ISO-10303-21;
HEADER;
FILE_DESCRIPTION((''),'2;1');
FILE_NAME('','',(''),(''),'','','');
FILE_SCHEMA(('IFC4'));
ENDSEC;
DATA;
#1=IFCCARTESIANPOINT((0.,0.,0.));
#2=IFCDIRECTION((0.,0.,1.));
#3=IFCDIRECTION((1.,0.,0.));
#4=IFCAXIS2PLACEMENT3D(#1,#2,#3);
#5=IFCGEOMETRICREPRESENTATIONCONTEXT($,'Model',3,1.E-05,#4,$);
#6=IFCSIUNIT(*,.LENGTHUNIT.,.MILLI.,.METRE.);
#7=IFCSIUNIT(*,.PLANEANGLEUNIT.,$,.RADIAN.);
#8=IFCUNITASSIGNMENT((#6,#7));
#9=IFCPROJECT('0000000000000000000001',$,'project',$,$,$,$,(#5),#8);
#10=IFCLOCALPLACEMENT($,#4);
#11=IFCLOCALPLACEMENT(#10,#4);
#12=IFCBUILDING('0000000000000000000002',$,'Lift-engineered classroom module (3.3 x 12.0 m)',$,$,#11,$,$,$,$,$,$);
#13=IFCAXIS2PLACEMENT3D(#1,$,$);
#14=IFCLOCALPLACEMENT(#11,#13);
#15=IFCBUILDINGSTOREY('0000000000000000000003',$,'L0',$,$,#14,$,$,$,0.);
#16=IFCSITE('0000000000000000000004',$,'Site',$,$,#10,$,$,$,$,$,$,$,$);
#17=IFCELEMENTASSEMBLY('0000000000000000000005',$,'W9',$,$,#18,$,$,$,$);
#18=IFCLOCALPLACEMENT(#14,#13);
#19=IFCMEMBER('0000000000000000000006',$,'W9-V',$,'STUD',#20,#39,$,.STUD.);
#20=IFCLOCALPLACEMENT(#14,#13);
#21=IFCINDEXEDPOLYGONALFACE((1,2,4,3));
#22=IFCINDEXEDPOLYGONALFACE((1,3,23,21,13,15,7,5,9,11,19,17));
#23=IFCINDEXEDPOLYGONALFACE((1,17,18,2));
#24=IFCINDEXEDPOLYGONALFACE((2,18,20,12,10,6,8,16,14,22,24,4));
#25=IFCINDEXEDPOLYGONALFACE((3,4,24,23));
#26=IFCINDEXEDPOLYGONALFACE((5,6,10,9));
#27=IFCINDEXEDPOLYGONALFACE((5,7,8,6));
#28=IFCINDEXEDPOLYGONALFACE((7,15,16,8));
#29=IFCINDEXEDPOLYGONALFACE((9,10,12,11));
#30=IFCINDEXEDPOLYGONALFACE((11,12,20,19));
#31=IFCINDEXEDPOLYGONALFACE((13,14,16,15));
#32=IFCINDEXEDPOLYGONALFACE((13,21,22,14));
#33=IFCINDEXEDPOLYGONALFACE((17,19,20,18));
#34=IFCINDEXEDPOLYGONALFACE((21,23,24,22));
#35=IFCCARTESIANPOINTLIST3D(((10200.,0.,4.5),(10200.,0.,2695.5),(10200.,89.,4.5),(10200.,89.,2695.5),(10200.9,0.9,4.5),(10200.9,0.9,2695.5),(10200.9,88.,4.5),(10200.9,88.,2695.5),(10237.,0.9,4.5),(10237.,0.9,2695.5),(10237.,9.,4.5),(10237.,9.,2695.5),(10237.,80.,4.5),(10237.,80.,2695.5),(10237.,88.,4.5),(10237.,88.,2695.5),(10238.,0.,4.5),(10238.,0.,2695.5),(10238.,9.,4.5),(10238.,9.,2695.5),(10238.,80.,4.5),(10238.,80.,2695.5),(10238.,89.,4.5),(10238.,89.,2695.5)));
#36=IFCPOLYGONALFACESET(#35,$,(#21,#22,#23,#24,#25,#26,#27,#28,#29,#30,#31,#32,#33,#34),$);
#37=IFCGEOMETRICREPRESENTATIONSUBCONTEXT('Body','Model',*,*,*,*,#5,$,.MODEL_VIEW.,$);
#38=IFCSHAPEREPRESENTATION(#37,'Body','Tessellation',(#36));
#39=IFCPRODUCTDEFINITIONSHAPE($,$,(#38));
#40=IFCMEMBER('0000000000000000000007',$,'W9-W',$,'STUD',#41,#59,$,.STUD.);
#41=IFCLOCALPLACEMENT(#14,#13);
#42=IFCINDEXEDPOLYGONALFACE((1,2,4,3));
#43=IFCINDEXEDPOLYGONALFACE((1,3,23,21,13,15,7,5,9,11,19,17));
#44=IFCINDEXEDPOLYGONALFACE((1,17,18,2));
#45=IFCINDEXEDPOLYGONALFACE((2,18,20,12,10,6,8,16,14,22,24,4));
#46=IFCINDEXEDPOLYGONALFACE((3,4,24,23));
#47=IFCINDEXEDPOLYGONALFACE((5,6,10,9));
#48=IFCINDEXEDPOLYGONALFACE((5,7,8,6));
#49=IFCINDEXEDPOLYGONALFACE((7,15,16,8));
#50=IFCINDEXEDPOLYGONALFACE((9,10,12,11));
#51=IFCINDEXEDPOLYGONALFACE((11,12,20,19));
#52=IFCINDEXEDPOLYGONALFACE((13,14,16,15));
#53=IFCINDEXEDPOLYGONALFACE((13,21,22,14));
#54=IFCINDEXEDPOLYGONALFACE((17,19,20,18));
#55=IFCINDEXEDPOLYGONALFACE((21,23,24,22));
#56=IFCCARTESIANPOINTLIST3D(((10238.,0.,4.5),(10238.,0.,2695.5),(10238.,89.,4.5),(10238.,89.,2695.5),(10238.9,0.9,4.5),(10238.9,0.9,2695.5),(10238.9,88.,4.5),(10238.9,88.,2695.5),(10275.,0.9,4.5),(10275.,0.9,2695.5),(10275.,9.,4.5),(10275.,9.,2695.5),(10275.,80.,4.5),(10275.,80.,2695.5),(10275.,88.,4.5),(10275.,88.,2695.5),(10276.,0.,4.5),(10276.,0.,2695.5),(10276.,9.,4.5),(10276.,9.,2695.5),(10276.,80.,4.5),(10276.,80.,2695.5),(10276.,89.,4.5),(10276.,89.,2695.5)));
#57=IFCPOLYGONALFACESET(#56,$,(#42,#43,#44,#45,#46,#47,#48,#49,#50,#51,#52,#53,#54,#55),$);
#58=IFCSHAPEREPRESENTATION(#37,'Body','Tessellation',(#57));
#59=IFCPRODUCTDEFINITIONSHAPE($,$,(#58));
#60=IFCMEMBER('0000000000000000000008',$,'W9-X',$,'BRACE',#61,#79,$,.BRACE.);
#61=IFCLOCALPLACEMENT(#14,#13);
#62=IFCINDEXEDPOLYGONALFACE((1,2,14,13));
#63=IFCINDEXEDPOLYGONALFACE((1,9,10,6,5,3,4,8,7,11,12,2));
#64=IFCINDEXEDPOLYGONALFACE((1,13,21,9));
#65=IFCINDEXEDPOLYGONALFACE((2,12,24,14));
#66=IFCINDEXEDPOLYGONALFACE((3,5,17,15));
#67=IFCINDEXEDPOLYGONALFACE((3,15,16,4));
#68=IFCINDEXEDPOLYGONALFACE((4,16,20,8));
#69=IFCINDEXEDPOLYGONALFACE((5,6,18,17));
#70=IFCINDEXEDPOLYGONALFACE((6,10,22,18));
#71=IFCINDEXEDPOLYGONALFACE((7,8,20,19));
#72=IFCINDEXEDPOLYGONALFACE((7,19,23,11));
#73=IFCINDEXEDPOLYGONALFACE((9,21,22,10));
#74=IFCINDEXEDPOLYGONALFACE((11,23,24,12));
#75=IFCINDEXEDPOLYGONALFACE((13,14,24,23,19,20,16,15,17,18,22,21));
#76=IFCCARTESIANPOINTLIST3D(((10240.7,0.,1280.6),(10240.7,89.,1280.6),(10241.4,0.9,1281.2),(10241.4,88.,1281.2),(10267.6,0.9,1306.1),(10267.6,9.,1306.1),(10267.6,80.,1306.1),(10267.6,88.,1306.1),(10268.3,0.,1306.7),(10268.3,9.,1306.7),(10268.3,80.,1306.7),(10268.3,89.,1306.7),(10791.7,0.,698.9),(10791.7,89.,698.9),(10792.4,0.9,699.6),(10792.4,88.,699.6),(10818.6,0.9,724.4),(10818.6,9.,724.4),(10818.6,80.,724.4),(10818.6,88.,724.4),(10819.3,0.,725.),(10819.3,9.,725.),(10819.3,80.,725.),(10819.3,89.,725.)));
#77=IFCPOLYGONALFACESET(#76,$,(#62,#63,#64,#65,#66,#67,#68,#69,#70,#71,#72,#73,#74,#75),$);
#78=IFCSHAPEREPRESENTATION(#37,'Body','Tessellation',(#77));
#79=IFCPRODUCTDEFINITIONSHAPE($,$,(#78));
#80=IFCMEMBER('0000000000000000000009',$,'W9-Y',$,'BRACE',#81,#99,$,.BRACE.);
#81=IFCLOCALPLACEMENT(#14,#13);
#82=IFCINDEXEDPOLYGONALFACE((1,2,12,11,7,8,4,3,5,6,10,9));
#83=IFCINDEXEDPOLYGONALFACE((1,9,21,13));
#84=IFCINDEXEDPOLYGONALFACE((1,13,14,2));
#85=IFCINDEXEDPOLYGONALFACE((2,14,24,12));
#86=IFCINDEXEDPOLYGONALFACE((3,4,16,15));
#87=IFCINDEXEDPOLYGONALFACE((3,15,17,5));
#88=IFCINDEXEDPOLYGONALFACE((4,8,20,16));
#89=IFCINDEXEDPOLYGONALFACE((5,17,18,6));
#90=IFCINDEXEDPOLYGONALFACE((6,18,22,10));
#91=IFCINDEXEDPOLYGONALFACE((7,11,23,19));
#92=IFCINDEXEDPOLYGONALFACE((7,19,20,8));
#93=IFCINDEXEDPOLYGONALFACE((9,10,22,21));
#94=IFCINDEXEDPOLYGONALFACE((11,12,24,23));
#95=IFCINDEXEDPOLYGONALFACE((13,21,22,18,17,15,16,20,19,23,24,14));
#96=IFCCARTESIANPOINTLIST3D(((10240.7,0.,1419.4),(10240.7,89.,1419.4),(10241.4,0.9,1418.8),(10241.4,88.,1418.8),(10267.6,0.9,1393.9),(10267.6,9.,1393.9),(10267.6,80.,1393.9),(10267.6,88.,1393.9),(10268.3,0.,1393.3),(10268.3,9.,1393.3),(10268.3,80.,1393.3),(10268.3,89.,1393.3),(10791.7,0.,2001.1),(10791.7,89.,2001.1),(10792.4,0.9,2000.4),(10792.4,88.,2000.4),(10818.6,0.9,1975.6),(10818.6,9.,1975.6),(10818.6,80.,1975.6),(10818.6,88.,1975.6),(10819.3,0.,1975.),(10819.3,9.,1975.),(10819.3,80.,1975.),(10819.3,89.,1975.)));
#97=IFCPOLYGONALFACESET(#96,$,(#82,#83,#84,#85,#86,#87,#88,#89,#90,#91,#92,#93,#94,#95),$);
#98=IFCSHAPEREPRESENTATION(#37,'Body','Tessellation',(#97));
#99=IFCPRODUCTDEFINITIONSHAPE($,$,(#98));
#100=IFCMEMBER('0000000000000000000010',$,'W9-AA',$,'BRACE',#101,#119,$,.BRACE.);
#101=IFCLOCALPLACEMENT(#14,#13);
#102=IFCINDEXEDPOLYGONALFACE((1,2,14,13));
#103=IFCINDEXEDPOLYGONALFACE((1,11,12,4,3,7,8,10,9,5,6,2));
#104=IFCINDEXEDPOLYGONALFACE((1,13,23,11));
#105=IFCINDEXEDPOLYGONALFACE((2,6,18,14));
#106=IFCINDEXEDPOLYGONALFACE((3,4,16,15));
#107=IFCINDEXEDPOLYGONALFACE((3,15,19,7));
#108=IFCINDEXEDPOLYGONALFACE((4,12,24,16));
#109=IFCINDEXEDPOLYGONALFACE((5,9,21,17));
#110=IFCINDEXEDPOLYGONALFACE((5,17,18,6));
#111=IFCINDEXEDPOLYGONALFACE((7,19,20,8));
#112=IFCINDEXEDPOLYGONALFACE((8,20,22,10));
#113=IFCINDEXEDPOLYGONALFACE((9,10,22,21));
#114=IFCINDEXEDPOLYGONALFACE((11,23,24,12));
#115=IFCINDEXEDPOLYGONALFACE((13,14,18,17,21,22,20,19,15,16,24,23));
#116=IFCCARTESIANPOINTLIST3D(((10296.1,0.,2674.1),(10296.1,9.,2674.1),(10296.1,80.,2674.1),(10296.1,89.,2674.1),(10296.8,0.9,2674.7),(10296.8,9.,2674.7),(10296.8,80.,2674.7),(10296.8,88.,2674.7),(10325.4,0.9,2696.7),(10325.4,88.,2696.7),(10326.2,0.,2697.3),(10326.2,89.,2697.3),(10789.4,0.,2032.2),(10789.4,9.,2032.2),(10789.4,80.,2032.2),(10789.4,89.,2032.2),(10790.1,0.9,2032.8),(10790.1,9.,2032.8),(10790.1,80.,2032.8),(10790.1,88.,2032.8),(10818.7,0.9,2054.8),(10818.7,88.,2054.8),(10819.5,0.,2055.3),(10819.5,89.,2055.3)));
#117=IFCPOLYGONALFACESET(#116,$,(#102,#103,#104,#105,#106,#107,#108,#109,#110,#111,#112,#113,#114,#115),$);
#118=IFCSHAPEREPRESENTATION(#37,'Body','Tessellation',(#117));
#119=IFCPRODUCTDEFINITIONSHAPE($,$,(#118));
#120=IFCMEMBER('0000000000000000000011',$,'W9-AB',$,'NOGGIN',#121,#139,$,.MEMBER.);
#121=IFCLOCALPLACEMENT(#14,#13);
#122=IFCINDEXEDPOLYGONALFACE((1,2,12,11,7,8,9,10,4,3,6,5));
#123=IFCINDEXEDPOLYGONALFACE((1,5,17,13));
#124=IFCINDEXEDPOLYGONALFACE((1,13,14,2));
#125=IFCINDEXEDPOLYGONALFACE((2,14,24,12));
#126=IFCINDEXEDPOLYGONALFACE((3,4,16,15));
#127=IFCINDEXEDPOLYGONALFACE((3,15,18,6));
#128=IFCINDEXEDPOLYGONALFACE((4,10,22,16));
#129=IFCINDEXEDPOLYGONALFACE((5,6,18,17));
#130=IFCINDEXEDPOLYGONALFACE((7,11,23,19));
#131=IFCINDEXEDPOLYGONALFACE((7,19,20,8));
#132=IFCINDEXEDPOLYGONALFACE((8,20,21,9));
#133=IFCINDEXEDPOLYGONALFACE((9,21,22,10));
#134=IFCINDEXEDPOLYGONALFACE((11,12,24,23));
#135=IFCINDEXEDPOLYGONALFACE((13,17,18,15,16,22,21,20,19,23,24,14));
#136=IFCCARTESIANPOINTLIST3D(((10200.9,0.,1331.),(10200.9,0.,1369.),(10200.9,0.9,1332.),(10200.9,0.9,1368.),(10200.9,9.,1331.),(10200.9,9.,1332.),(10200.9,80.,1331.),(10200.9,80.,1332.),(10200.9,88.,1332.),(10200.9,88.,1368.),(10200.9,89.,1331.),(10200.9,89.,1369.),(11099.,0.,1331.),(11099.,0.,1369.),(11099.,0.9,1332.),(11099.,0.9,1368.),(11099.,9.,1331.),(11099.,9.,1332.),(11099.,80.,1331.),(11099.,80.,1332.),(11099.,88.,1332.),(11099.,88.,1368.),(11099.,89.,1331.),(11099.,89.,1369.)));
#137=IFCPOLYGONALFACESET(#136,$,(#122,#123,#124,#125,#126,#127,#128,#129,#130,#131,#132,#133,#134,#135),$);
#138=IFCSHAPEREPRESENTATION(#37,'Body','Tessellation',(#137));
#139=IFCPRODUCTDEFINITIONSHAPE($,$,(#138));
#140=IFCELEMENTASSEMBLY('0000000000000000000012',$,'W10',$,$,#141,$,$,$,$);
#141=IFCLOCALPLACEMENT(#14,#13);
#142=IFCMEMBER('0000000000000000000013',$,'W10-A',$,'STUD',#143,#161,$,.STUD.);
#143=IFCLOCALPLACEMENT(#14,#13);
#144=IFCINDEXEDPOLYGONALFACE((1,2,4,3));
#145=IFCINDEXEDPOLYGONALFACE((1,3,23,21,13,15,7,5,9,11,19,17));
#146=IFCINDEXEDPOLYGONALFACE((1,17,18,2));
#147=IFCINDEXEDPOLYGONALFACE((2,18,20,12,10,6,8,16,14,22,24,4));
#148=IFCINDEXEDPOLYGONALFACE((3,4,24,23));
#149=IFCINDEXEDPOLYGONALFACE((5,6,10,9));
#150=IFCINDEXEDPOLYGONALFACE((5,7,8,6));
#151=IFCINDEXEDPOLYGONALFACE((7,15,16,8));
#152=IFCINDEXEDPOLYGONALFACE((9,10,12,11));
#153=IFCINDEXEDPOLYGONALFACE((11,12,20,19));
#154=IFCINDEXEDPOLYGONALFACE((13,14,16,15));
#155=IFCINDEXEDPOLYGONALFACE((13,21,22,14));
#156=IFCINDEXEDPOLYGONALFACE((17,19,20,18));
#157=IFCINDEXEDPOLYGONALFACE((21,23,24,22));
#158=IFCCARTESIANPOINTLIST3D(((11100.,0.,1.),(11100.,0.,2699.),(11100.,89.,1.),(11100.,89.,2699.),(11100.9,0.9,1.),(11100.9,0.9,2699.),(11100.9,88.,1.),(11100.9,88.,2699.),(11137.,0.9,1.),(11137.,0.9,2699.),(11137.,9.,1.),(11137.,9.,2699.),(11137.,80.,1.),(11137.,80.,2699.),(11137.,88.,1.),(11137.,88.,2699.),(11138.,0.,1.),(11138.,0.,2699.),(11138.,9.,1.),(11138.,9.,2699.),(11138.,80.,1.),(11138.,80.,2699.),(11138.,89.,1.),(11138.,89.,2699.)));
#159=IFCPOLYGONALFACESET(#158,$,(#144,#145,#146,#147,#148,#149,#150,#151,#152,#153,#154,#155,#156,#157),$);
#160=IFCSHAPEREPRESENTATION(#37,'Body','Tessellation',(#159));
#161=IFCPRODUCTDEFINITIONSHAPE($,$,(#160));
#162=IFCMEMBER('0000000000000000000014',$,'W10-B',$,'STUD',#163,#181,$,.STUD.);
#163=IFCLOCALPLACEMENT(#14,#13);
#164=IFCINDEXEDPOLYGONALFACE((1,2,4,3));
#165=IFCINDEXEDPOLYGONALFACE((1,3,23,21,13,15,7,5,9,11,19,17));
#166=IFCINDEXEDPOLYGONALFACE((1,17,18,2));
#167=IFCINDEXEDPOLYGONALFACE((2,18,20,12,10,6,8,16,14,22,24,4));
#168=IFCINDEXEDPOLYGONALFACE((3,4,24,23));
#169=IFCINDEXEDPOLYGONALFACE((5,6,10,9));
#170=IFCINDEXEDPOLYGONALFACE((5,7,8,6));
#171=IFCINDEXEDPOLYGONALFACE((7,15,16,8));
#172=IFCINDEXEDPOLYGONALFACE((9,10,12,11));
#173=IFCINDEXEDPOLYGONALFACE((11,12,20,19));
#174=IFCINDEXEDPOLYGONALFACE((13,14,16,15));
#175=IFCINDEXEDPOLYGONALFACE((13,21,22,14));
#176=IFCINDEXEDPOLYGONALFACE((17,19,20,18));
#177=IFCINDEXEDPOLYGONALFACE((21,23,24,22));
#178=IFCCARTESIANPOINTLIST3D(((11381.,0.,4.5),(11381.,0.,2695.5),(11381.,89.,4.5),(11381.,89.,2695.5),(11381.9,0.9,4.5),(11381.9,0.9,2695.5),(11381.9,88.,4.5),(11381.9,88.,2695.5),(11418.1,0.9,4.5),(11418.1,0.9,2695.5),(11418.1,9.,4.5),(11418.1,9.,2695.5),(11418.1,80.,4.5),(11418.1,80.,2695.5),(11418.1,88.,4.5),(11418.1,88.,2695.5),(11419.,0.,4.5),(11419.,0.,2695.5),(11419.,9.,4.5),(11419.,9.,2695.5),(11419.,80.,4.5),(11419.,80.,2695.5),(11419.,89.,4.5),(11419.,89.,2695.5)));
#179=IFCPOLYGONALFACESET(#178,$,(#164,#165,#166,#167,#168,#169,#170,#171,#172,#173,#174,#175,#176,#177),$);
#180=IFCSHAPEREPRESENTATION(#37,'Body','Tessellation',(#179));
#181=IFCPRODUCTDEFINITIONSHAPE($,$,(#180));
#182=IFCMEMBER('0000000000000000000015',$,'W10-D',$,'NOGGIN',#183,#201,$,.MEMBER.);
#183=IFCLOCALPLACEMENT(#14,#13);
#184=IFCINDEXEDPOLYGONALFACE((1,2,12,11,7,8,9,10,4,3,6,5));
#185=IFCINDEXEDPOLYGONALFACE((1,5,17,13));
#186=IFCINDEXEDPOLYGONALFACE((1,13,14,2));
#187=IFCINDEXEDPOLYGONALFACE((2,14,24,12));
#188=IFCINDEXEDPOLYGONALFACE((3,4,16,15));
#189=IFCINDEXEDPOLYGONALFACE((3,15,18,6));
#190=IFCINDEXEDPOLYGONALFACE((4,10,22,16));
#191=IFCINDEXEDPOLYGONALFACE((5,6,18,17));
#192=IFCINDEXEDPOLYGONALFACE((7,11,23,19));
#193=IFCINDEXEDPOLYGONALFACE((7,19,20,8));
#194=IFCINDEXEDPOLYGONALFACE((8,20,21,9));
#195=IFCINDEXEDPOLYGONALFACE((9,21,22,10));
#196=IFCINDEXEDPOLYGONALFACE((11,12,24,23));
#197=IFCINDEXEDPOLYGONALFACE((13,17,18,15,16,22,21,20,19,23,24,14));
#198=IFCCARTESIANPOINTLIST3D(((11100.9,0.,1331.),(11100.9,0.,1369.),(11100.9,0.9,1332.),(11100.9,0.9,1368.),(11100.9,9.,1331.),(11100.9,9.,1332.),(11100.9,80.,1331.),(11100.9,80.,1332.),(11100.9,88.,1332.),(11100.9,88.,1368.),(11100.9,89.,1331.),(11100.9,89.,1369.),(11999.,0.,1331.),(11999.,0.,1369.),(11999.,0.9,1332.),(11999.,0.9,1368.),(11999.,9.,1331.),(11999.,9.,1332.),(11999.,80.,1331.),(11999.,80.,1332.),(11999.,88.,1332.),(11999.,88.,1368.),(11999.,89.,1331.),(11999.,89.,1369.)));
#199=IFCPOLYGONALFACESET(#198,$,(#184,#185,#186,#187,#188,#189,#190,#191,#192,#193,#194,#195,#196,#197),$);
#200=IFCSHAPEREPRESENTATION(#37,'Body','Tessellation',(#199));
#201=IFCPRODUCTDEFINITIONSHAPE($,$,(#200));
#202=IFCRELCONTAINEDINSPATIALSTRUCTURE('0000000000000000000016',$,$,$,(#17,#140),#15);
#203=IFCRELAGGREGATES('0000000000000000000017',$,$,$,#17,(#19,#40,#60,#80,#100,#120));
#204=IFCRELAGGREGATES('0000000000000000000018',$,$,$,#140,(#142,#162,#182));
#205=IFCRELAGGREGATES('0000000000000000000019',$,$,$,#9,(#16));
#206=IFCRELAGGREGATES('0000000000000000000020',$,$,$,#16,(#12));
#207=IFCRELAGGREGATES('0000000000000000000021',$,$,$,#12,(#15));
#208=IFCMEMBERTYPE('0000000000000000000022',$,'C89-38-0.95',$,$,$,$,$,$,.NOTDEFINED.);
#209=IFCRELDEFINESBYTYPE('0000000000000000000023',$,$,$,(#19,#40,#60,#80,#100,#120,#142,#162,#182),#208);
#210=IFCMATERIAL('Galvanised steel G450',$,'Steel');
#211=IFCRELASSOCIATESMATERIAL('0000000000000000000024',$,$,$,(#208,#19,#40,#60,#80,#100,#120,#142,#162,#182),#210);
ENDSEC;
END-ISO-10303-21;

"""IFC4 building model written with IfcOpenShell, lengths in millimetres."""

from ifc_helpers import new_model, si_unit, frame, origin, origin_with_axes, origin_2d, place, context, subcontext, project, spatial, c_section, extrude, material, material_profile, profile_set, profile_usage, type_object, element, aggregate, save


model = new_model("IFC4")

# Units and contexts
model_context = context("Model", 3, precision=1e-05, world=origin_with_axes())
body_context = subcontext(model_context, "Body", "Model", "MODEL_VIEW")
ifc_project = project(units=[si_unit("LENGTHUNIT", "METRE", prefix="MILLI"), si_unit("PLANEANGLEUNIT", "RADIAN")], contexts=[model_context])

# Site, building, storey
site_placement = place(None, origin_with_axes())
site = spatial("IfcSite", under=ifc_project, at=site_placement, Name="Site")
building_placement = place(site_placement, origin_with_axes())
building = spatial("IfcBuilding", under=site, at=building_placement, Name="Lift-engineered classroom module (3.3 x 12.0 m)")
storey_placement = place(building_placement, origin())
storey = spatial("IfcBuildingStorey", under=building, at=storey_placement, Name="L0", Elevation=0.0)

# Element assemblies, members
assembly_1_placement = place(storey_placement, frame((7500.0, 44.5, 0.0)))
assembly_1 = element("IfcElementAssembly", 1, at=assembly_1_placement, inside=storey, Name="W9")
ifc_material = material(Name="Galvanised steel G450", Category="Steel")
ifc_material_profile = material_profile(ifc_material, c_section(Depth=89.0, Width=38.0, WallThickness=0.9, Girth=9.0, at=origin_2d()), Name="C89-38-0.95")
ifc_profile_set = profile_set([ifc_material_profile], Name="C89-38-0.95")
ifc_profile_usage = profile_usage(ifc_profile_set)
member_type = type_object("IfcMemberType", Name="C89-38-0.95", PredefinedType="NOTDEFINED", material=ifc_profile_set)
member_1_placement = place(assembly_1_placement, frame((2719.0, 0.0, 2695.5), z_axis=(0.0, 0.0, -1.0), x_axis=(1.0, 0.0, 0.0)))
member_1 = element("IfcMember", 2, at=member_1_placement, type_object=member_type, material=ifc_profile_usage, Name="W9-V", ObjectType="STUD", PredefinedType="STUD", context=body_context, shape_type="SweptSolid", body=[
    extrude(c_section(Depth=89.0, Width=38.0, WallThickness=0.9, Girth=9.0, at=origin_2d()), origin(), (0.0, 0.0, 1.0), 2691.0),
])
member_2_placement = place(assembly_1_placement, frame((2757.0, 0.0, 2695.5), z_axis=(0.0, 0.0, -1.0), x_axis=(1.0, 0.0, 0.0)))
member_2 = element("IfcMember", 3, at=member_2_placement, type_object=member_type, material=ifc_profile_usage, Name="W9-W", ObjectType="STUD", PredefinedType="STUD", context=body_context, shape_type="SweptSolid", body=[
    extrude(c_section(Depth=89.0, Width=38.0, WallThickness=0.9, Girth=9.0, at=origin_2d()), origin(), (0.0, 0.0, 1.0), 2691.0),
])
member_3_placement = place(assembly_1_placement, frame((2754.5, 0.0, 1293.6), z_axis=(0.687721, 0.0, -0.725975), x_axis=(0.725975, 0.0, 0.687721)))
member_3 = element("IfcMember", 4, at=member_3_placement, type_object=member_type, material=ifc_profile_usage, Name="W9-X", ObjectType="BRACE", PredefinedType="BRACE", context=body_context, shape_type="SweptSolid", body=[
    extrude(c_section(Depth=89.0, Width=38.0, WallThickness=0.9, Girth=9.0, at=origin_2d()), origin(), (0.0, 0.0, 1.0), 801.2),
])
member_4_placement = place(assembly_1_placement, frame((3305.5, 0.0, 1988.0), z_axis=(-0.687721, 0.0, -0.725975), x_axis=(0.725975, 0.0, -0.687721)))
member_4 = element("IfcMember", 5, at=member_4_placement, type_object=member_type, material=ifc_profile_usage, Name="W9-Y", ObjectType="BRACE", PredefinedType="BRACE", context=body_context, shape_type="SweptSolid", body=[
    extrude(c_section(Depth=89.0, Width=38.0, WallThickness=0.9, Girth=9.0, at=origin_2d()), origin(), (0.0, 0.0, 1.0), 801.2),
])
member_5_placement = place(assembly_1_placement, frame((3304.4, 0.0, 2043.8), z_axis=(-0.609305, 0.0, 0.792936), x_axis=(-0.792936, 0.0, -0.609305)))
member_5 = element("IfcMember", 6, at=member_5_placement, type_object=member_type, material=ifc_profile_usage, Name="W9-AA", ObjectType="BRACE", PredefinedType="BRACE", context=body_context, shape_type="SweptSolid", body=[
    extrude(c_section(Depth=89.0, Width=38.0, WallThickness=0.9, Girth=9.0, at=origin_2d()), origin(), (0.0, 0.0, 1.0), 809.6),
])
member_6_placement = place(assembly_1_placement, frame((3599.0, 0.0, 1350.0), z_axis=(-1.0, 0.0, 0.0), x_axis=(0.0, 0.0, -1.0)))
member_6 = element("IfcMember", 7, at=member_6_placement, type_object=member_type, material=ifc_profile_usage, Name="W9-AB", ObjectType="NOGGIN", PredefinedType="MEMBER", context=body_context, shape_type="SweptSolid", body=[
    extrude(c_section(Depth=89.0, Width=38.0, WallThickness=0.9, Girth=9.0, at=origin_2d()), origin(), (0.0, 0.0, 1.0), 898.1),
])
aggregate(assembly_1, [member_1, member_2, member_3, member_4, member_5, member_6])
assembly_2_placement = place(storey_placement, frame((11100.0, 44.5, 0.0)))
assembly_2 = element("IfcElementAssembly", 8, at=assembly_2_placement, inside=storey, Name="W10")
member_7_placement = place(assembly_2_placement, frame((19.0, 0.0, 2699.1), z_axis=(0.0, 0.0, -1.0), x_axis=(1.0, 0.0, 0.0)))
member_7 = element("IfcMember", 9, at=member_7_placement, type_object=member_type, material=ifc_profile_usage, Name="W10-A", ObjectType="STUD", PredefinedType="STUD", context=body_context, shape_type="SweptSolid", body=[
    extrude(c_section(Depth=89.0, Width=38.0, WallThickness=0.9, Girth=9.0, at=origin_2d()), origin(), (0.0, 0.0, 1.0), 2698.1),
])
member_8_placement = place(assembly_2_placement, frame((300.0, 0.0, 2695.5), z_axis=(0.0, 0.0, -1.0), x_axis=(1.0, 0.0, 0.0)))
member_8 = element("IfcMember", 10, at=member_8_placement, type_object=member_type, material=ifc_profile_usage, Name="W10-B", ObjectType="STUD", PredefinedType="STUD", context=body_context, shape_type="SweptSolid", body=[
    extrude(c_section(Depth=89.0, Width=38.0, WallThickness=0.9, Girth=9.0, at=origin_2d()), origin(), (0.0, 0.0, 1.0), 2691.0),
])
member_9_placement = place(assembly_2_placement, frame((899.0, 0.0, 1350.0), z_axis=(-1.0, 0.0, 0.0), x_axis=(0.0, 0.0, -1.0)))
member_9 = element("IfcMember", 11, at=member_9_placement, type_object=member_type, material=ifc_profile_usage, Name="W10-D", ObjectType="NOGGIN", PredefinedType="MEMBER", context=body_context, shape_type="SweptSolid", body=[
    extrude(c_section(Depth=89.0, Width=38.0, WallThickness=0.9, Girth=9.0, at=origin_2d()), origin(), (0.0, 0.0, 1.0), 898.1),
])
aggregate(assembly_2, [member_7, member_8, member_9])

save(model, "model.ifc")
